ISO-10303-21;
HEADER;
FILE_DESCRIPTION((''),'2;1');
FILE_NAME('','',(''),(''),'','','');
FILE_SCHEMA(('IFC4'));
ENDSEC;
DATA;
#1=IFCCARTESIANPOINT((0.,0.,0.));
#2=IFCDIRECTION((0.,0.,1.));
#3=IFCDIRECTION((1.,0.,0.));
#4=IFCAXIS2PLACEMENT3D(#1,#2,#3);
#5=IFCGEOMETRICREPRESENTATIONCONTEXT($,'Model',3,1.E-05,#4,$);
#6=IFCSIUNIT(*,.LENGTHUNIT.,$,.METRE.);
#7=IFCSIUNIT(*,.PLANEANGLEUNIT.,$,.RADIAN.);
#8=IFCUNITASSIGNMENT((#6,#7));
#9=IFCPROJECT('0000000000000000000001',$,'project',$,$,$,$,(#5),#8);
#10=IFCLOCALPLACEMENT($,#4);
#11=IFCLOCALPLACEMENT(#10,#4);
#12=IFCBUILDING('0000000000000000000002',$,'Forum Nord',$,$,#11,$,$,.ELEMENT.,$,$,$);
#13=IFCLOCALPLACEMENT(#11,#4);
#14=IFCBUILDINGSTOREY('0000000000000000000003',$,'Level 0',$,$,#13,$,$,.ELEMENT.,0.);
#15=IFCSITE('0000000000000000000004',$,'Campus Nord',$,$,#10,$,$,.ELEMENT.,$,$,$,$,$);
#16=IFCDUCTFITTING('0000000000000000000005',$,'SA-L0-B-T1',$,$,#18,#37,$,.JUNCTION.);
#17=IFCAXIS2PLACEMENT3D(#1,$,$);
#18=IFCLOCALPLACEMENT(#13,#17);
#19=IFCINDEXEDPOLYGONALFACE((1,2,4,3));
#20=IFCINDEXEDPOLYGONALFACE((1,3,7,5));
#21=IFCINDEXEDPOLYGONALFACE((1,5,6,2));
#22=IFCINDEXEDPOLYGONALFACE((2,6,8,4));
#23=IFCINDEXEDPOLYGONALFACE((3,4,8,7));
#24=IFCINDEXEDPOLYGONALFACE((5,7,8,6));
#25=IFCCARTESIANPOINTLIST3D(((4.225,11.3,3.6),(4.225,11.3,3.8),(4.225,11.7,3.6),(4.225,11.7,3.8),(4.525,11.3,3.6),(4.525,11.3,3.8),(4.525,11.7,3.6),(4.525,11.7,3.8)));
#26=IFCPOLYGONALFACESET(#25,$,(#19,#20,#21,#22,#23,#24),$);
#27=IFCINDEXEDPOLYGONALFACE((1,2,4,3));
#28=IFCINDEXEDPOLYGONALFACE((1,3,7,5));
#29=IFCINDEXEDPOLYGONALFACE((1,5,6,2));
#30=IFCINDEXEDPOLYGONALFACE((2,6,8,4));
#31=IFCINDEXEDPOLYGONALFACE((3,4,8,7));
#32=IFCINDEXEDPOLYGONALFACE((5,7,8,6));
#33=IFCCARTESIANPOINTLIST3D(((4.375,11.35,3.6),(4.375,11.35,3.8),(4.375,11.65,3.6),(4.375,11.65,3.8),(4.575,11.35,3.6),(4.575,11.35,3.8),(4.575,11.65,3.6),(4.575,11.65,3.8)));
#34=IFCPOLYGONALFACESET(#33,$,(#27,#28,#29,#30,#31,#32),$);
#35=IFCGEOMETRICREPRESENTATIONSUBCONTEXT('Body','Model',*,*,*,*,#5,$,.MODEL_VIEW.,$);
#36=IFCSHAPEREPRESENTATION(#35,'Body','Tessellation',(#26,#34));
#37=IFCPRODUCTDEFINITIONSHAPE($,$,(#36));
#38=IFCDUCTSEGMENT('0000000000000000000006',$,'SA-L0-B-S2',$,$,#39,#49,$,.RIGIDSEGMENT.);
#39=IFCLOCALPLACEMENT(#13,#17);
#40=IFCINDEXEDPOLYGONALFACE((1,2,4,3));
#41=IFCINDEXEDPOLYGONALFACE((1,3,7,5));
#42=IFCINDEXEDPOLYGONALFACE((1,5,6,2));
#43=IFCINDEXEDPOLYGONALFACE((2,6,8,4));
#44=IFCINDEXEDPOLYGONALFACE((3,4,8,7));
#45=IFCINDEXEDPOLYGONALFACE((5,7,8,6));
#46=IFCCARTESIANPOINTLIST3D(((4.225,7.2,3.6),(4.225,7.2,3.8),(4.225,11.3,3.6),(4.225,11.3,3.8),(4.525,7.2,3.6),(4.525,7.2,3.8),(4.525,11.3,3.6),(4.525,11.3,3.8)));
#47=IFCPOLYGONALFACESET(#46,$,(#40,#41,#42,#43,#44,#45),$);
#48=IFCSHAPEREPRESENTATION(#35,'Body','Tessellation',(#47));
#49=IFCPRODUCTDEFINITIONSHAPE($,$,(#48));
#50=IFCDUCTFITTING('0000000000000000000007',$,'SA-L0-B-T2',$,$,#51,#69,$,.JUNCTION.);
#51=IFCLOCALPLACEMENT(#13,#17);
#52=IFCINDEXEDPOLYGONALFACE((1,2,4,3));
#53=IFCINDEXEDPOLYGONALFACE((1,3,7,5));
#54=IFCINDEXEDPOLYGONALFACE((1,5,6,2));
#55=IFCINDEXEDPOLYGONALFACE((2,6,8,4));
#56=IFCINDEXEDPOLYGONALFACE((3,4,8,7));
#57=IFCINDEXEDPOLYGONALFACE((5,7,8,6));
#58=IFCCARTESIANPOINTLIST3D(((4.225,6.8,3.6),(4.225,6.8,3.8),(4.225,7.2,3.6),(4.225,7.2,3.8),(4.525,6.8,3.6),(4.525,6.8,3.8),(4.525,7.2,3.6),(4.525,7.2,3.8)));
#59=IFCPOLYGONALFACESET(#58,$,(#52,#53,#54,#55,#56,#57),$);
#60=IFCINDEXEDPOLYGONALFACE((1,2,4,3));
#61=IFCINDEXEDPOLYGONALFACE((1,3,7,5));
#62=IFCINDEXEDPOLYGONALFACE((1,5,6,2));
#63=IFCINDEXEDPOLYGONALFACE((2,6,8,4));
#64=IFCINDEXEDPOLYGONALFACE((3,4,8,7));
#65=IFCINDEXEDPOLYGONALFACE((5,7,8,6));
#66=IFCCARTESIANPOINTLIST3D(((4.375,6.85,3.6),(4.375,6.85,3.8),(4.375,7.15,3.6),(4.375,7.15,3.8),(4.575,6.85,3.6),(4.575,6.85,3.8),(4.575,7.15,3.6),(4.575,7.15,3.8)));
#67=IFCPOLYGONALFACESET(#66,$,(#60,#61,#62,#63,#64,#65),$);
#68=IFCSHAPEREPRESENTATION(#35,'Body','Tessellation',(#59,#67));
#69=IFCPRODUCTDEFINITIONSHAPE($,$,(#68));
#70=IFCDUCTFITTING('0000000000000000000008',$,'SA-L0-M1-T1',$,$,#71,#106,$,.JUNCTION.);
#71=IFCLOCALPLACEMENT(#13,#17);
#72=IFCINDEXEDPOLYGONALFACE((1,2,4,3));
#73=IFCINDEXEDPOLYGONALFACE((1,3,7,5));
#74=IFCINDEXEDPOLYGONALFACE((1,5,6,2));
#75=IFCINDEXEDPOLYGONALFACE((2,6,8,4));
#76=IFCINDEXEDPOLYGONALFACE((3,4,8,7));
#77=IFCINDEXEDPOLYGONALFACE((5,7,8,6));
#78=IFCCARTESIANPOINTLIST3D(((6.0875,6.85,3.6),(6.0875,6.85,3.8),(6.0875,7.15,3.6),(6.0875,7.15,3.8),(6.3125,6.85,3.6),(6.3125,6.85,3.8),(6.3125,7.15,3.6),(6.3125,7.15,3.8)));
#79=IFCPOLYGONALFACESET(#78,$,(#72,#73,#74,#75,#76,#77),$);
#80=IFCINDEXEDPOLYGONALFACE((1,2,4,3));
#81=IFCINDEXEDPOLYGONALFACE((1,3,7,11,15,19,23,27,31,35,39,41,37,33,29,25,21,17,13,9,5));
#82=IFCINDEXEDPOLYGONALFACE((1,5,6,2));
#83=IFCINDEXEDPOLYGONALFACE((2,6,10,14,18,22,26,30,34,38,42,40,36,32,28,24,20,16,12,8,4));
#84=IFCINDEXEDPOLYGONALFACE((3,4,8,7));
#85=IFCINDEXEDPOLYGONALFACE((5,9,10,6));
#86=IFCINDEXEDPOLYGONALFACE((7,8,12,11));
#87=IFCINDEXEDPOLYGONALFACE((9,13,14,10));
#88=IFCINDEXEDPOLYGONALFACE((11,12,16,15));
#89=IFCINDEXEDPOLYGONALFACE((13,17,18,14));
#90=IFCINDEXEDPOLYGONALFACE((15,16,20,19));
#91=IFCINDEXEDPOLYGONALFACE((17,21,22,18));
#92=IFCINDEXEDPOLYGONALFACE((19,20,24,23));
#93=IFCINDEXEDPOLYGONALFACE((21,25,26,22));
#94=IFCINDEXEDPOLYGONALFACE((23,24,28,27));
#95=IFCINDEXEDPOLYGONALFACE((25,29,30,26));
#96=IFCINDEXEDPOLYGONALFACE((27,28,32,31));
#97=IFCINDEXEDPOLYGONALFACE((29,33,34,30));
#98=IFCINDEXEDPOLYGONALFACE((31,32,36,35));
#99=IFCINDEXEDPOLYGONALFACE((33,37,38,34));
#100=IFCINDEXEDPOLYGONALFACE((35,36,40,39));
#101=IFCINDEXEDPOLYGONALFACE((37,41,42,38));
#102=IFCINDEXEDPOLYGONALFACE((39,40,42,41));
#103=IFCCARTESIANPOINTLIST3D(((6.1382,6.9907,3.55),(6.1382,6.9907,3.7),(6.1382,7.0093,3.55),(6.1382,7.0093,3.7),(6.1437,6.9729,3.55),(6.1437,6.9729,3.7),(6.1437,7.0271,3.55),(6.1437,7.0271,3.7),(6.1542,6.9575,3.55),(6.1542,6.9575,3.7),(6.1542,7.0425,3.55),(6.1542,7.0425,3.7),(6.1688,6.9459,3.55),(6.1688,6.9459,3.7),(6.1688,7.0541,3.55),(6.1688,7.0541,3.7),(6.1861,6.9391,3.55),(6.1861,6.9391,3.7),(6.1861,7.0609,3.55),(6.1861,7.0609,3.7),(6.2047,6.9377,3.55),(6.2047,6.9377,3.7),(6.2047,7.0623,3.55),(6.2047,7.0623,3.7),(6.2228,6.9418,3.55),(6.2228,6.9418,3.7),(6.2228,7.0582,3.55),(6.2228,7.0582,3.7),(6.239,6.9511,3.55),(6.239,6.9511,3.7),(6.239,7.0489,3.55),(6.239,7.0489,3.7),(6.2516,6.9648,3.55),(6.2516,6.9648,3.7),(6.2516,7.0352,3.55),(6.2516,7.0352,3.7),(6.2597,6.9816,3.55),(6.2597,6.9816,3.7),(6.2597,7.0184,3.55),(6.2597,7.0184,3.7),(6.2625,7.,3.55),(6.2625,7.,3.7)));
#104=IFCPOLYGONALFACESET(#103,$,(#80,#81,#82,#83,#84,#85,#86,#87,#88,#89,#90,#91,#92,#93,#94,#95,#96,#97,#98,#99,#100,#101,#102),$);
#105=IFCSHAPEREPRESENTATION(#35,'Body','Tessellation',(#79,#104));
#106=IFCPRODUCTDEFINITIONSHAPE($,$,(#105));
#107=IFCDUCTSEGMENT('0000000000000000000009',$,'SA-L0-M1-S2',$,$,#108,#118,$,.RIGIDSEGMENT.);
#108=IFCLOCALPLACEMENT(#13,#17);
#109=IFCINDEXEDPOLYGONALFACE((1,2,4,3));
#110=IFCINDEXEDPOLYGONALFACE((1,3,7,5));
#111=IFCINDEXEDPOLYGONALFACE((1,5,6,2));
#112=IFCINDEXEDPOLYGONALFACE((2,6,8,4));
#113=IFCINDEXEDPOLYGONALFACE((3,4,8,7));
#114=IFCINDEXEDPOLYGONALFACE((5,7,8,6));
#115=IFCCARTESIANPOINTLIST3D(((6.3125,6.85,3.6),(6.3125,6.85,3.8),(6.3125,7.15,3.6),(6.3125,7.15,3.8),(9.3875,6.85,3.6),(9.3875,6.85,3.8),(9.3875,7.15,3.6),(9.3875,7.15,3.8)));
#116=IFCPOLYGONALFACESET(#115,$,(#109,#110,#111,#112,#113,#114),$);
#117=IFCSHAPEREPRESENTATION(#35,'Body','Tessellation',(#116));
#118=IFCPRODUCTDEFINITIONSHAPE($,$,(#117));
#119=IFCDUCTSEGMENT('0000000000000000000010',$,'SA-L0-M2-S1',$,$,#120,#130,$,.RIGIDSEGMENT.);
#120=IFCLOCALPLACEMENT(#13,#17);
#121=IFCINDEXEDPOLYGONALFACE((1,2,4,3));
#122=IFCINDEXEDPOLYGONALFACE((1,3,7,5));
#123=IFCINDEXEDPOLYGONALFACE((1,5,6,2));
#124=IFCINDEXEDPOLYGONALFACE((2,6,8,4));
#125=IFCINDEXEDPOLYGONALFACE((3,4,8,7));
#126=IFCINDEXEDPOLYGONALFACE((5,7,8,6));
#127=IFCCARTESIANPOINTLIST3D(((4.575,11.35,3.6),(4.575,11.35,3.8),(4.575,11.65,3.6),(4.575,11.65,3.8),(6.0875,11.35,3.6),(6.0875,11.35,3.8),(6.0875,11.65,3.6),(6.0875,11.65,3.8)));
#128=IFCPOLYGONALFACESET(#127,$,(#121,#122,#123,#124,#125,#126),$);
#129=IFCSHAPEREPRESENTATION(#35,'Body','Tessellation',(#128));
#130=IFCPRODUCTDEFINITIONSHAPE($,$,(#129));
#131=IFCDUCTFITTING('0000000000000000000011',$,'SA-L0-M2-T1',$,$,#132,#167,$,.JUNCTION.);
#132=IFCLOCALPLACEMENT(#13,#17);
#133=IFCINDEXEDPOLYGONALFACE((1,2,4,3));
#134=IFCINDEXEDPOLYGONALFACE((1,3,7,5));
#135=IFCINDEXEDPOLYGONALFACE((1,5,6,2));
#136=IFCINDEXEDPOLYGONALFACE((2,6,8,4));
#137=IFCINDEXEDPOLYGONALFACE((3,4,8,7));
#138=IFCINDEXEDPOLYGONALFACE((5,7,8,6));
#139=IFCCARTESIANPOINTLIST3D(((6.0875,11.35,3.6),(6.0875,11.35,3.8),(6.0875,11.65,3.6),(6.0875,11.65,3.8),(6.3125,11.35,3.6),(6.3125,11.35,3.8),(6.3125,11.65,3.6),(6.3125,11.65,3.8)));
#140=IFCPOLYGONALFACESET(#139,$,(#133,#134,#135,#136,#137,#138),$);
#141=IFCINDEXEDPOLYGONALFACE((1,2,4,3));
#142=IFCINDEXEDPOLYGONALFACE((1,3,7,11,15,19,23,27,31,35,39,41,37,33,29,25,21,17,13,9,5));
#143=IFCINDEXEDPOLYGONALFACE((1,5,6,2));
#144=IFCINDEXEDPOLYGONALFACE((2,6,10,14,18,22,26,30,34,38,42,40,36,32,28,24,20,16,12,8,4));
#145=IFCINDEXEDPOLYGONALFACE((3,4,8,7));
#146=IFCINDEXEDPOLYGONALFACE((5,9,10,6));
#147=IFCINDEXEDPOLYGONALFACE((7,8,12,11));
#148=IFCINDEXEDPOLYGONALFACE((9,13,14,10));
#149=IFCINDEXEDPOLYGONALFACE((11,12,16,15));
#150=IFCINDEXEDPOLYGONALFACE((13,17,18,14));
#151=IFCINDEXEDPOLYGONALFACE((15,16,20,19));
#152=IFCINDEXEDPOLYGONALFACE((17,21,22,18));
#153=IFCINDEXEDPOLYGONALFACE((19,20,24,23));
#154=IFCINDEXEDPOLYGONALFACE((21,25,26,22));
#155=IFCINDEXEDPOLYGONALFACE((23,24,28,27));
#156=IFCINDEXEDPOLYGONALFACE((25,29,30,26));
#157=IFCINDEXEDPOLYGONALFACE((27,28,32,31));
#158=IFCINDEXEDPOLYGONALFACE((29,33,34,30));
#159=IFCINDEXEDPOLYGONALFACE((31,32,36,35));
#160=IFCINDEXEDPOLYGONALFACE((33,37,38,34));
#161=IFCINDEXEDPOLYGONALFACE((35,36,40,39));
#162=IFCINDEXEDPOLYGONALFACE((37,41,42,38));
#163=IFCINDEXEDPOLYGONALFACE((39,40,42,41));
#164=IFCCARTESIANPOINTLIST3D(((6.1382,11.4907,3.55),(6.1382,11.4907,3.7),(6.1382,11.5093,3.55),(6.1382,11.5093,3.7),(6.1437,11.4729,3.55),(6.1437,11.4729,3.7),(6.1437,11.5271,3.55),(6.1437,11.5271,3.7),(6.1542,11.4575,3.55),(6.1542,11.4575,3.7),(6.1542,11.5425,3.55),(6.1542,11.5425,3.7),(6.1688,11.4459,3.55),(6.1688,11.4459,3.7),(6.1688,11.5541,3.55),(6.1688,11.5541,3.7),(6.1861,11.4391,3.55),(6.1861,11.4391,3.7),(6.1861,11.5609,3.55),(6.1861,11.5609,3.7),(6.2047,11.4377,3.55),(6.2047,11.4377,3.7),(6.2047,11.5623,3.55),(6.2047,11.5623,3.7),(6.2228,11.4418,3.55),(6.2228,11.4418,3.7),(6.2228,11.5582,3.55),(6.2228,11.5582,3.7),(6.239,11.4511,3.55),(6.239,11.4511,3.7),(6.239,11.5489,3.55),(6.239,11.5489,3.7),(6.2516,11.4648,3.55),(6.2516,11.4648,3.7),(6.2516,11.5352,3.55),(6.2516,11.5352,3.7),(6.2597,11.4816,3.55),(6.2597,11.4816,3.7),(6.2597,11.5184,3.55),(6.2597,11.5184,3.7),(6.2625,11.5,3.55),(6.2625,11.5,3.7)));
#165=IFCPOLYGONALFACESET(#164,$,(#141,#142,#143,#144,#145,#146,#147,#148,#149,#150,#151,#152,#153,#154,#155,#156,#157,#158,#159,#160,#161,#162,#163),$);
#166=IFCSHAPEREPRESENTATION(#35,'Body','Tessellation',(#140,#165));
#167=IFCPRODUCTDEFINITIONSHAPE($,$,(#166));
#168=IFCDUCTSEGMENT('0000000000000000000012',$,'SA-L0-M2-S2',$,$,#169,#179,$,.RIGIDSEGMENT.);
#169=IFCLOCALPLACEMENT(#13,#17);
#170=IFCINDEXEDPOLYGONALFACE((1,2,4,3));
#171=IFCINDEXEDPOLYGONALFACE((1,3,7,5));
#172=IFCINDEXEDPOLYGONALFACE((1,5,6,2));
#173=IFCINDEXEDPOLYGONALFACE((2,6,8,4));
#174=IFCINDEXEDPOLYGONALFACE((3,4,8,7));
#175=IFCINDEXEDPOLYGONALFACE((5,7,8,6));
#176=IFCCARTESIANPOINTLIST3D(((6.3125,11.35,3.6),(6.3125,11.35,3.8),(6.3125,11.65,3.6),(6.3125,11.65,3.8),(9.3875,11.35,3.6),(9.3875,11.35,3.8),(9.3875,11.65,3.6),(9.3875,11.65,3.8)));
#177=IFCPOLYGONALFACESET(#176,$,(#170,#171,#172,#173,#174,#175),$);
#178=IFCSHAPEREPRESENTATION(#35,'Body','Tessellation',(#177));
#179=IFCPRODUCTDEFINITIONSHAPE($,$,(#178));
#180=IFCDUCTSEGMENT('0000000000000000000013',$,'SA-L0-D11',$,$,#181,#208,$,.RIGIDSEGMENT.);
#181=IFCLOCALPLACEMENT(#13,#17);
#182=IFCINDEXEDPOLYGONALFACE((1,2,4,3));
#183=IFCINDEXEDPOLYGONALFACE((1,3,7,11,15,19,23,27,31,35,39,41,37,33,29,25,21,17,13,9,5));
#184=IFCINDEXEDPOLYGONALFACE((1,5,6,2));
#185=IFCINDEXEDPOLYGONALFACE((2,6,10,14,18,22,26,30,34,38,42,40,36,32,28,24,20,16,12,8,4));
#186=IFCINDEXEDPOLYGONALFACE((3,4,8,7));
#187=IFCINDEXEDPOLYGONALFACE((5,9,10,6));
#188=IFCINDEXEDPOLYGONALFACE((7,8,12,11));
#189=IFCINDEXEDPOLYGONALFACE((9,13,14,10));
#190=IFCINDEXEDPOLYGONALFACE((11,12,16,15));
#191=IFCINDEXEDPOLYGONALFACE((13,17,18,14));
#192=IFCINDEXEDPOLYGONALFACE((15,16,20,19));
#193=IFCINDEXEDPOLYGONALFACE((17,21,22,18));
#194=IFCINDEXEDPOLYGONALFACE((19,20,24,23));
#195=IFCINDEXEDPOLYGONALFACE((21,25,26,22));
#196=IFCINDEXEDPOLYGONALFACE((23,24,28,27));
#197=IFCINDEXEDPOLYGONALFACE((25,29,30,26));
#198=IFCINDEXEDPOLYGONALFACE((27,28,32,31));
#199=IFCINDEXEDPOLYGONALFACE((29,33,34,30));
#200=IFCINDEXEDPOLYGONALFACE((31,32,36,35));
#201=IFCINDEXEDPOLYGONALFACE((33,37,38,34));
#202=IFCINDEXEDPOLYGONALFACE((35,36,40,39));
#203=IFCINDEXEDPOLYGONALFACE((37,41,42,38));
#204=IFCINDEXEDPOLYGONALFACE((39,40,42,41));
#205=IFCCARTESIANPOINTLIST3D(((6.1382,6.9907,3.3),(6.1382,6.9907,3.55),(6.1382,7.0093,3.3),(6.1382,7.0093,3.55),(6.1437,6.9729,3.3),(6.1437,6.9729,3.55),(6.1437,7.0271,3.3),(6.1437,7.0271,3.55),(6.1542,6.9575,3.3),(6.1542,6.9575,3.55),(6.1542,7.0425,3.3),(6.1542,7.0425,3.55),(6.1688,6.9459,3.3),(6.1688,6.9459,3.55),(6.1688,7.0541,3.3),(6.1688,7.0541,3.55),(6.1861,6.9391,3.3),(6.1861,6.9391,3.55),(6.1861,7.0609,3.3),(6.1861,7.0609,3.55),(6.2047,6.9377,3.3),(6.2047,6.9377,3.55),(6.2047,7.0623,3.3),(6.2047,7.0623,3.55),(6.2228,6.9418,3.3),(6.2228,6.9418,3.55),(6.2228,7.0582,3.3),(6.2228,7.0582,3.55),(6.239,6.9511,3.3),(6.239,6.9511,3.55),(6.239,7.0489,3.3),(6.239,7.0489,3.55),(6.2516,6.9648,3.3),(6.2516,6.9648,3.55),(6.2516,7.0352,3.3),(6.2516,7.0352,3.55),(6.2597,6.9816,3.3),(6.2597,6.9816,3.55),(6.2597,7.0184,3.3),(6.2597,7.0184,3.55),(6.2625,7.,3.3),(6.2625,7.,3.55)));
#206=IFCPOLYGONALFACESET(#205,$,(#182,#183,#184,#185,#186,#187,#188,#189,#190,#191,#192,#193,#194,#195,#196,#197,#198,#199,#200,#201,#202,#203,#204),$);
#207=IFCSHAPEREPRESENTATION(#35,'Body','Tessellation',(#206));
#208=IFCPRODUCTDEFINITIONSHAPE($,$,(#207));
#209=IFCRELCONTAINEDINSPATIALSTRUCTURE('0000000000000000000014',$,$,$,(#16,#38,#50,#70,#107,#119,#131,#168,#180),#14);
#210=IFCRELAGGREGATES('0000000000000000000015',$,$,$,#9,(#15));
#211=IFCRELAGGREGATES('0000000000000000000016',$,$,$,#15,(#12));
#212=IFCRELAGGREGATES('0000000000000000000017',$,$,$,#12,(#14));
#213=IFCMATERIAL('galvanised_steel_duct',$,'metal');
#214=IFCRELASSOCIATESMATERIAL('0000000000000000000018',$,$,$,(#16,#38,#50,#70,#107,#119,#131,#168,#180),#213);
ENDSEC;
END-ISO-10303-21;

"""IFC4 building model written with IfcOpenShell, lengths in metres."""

from ifc_helpers import new_model, si_unit, frame, origin_with_axes, origin_2d_with_axis, place, context, subcontext, project, spatial, rectangle, circle, extrude, material, element, save


model = new_model("IFC4")

# Units and contexts
model_context = context("Model", 3, precision=1e-05, world=origin_with_axes())
body_context = subcontext(model_context, "Body", "Model", "MODEL_VIEW")
ifc_project = project(units=[si_unit("LENGTHUNIT", "METRE"), si_unit("PLANEANGLEUNIT", "RADIAN")], contexts=[model_context])

# Site, building, storey
site_placement = place(None, origin_with_axes())
site = spatial("IfcSite", under=ifc_project, at=site_placement, Name="Campus Nord", CompositionType="ELEMENT")
building_placement = place(site_placement, origin_with_axes())
building = spatial("IfcBuilding", under=site, at=building_placement, Name="Forum Nord", CompositionType="ELEMENT")
storey_placement = place(building_placement, origin_with_axes())
storey = spatial("IfcBuildingStorey", under=building, at=storey_placement, Name="Level 0", CompositionType="ELEMENT", Elevation=0.0)

# Duct fitting
ifc_material_1 = material(Name="galvanised_steel_duct", Category="metal")
duct_fitting_1_placement = place(storey_placement, frame((4.375, 11.7, 3.7), z_axis=(0.0, -1.0, 0.0), x_axis=(1.0, 0.0, 0.0)))
element("IfcDuctFitting", 1, at=duct_fitting_1_placement, inside=storey, material=ifc_material_1, Name="SA-L0-B-T1", PredefinedType="JUNCTION", context=body_context, shape_type="SweptSolid", body=[
    extrude(rectangle(XDim=0.3, YDim=0.2, at=origin_2d_with_axis()), origin_with_axes(), (0.0, 0.0, 1.0), 0.4),
    extrude(rectangle(XDim=0.3, YDim=0.2, at=origin_2d_with_axis()), frame((0.0, 0.0, 0.2), z_axis=(1.0, 0.0, 0.0), x_axis=(0.0, 0.0, -1.0)), (0.0, 0.0, 1.0), 0.2),
])

# Duct segment
duct_segment_1_placement = place(storey_placement, frame((4.375, 11.3, 3.7), z_axis=(0.0, -1.0, 0.0), x_axis=(1.0, 0.0, 0.0)))
element("IfcDuctSegment", 2, at=duct_segment_1_placement, inside=storey, material=ifc_material_1, Name="SA-L0-B-S2", PredefinedType="RIGIDSEGMENT", context=body_context, shape_type="SweptSolid", body=[
    extrude(rectangle(XDim=0.3, YDim=0.2, at=origin_2d_with_axis()), origin_with_axes(), (0.0, 0.0, 1.0), 4.1),
])

# Duct fittings
duct_fitting_2_placement = place(storey_placement, frame((4.375, 7.2, 3.7), z_axis=(0.0, -1.0, 0.0), x_axis=(1.0, 0.0, 0.0)))
element("IfcDuctFitting", 3, at=duct_fitting_2_placement, inside=storey, material=ifc_material_1, Name="SA-L0-B-T2", PredefinedType="JUNCTION", context=body_context, shape_type="SweptSolid", body=[
    extrude(rectangle(XDim=0.3, YDim=0.2, at=origin_2d_with_axis()), origin_with_axes(), (0.0, 0.0, 1.0), 0.4),
    extrude(rectangle(XDim=0.3, YDim=0.2, at=origin_2d_with_axis()), frame((0.0, 0.0, 0.2), z_axis=(1.0, 0.0, 0.0), x_axis=(0.0, 0.0, -1.0)), (0.0, 0.0, 1.0), 0.2),
])
duct_fitting_3_placement = place(storey_placement, frame((6.0875, 7.0, 3.7), z_axis=(1.0, 0.0, 0.0), x_axis=(0.0, 1.0, 0.0)))
element("IfcDuctFitting", 4, at=duct_fitting_3_placement, inside=storey, material=ifc_material_1, Name="SA-L0-M1-T1", PredefinedType="JUNCTION", context=body_context, shape_type="SweptSolid", body=[
    extrude(rectangle(XDim=0.3, YDim=0.2, at=origin_2d_with_axis()), origin_with_axes(), (0.0, 0.0, 1.0), 0.225),
    extrude(circle(Radius=0.0625, at=origin_2d_with_axis()), frame((0.0, 0.0, 0.1125), z_axis=(0.0, -1.0, 0.0), x_axis=(0.0, 0.0, 1.0)), (0.0, 0.0, 1.0), 0.15),
])

# Duct segments
duct_segment_2_placement = place(storey_placement, frame((6.3125, 7.0, 3.7), z_axis=(1.0, 0.0, 0.0), x_axis=(0.0, 1.0, 0.0)))
element("IfcDuctSegment", 5, at=duct_segment_2_placement, inside=storey, material=ifc_material_1, Name="SA-L0-M1-S2", PredefinedType="RIGIDSEGMENT", context=body_context, shape_type="SweptSolid", body=[
    extrude(rectangle(XDim=0.3, YDim=0.2, at=origin_2d_with_axis()), origin_with_axes(), (0.0, 0.0, 1.0), 3.075),
])
duct_segment_3_placement = place(storey_placement, frame((4.575, 11.5, 3.7), z_axis=(1.0, 0.0, 0.0), x_axis=(0.0, 1.0, 0.0)))
element("IfcDuctSegment", 6, at=duct_segment_3_placement, inside=storey, material=ifc_material_1, Name="SA-L0-M2-S1", PredefinedType="RIGIDSEGMENT", context=body_context, shape_type="SweptSolid", body=[
    extrude(rectangle(XDim=0.3, YDim=0.2, at=origin_2d_with_axis()), origin_with_axes(), (0.0, 0.0, 1.0), 1.5125),
])

# Duct fitting
duct_fitting_4_placement = place(storey_placement, frame((6.0875, 11.5, 3.7), z_axis=(1.0, 0.0, 0.0), x_axis=(0.0, 1.0, 0.0)))
element("IfcDuctFitting", 7, at=duct_fitting_4_placement, inside=storey, material=ifc_material_1, Name="SA-L0-M2-T1", PredefinedType="JUNCTION", context=body_context, shape_type="SweptSolid", body=[
    extrude(rectangle(XDim=0.3, YDim=0.2, at=origin_2d_with_axis()), origin_with_axes(), (0.0, 0.0, 1.0), 0.225),
    extrude(circle(Radius=0.0625, at=origin_2d_with_axis()), frame((0.0, 0.0, 0.1125), z_axis=(0.0, -1.0, 0.0), x_axis=(0.0, 0.0, 1.0)), (0.0, 0.0, 1.0), 0.15),
])

# Duct segments
duct_segment_4_placement = place(storey_placement, frame((6.3125, 11.5, 3.7), z_axis=(1.0, 0.0, 0.0), x_axis=(0.0, 1.0, 0.0)))
element("IfcDuctSegment", 8, at=duct_segment_4_placement, inside=storey, material=ifc_material_1, Name="SA-L0-M2-S2", PredefinedType="RIGIDSEGMENT", context=body_context, shape_type="SweptSolid", body=[
    extrude(rectangle(XDim=0.3, YDim=0.2, at=origin_2d_with_axis()), origin_with_axes(), (0.0, 0.0, 1.0), 3.075),
])
duct_segment_5_placement = place(storey_placement, frame((6.2, 7.0, 3.55), z_axis=(0.0, 0.0, -1.0), x_axis=(1.0, 0.0, 0.0)))
element("IfcDuctSegment", 9, at=duct_segment_5_placement, inside=storey, material=ifc_material_1, Name="SA-L0-D11", PredefinedType="RIGIDSEGMENT", context=body_context, shape_type="SweptSolid", body=[
    extrude(circle(Radius=0.0625, at=origin_2d_with_axis()), origin_with_axes(), (0.0, 0.0, 1.0), 0.25),
])

save(model, "model.ifc")
